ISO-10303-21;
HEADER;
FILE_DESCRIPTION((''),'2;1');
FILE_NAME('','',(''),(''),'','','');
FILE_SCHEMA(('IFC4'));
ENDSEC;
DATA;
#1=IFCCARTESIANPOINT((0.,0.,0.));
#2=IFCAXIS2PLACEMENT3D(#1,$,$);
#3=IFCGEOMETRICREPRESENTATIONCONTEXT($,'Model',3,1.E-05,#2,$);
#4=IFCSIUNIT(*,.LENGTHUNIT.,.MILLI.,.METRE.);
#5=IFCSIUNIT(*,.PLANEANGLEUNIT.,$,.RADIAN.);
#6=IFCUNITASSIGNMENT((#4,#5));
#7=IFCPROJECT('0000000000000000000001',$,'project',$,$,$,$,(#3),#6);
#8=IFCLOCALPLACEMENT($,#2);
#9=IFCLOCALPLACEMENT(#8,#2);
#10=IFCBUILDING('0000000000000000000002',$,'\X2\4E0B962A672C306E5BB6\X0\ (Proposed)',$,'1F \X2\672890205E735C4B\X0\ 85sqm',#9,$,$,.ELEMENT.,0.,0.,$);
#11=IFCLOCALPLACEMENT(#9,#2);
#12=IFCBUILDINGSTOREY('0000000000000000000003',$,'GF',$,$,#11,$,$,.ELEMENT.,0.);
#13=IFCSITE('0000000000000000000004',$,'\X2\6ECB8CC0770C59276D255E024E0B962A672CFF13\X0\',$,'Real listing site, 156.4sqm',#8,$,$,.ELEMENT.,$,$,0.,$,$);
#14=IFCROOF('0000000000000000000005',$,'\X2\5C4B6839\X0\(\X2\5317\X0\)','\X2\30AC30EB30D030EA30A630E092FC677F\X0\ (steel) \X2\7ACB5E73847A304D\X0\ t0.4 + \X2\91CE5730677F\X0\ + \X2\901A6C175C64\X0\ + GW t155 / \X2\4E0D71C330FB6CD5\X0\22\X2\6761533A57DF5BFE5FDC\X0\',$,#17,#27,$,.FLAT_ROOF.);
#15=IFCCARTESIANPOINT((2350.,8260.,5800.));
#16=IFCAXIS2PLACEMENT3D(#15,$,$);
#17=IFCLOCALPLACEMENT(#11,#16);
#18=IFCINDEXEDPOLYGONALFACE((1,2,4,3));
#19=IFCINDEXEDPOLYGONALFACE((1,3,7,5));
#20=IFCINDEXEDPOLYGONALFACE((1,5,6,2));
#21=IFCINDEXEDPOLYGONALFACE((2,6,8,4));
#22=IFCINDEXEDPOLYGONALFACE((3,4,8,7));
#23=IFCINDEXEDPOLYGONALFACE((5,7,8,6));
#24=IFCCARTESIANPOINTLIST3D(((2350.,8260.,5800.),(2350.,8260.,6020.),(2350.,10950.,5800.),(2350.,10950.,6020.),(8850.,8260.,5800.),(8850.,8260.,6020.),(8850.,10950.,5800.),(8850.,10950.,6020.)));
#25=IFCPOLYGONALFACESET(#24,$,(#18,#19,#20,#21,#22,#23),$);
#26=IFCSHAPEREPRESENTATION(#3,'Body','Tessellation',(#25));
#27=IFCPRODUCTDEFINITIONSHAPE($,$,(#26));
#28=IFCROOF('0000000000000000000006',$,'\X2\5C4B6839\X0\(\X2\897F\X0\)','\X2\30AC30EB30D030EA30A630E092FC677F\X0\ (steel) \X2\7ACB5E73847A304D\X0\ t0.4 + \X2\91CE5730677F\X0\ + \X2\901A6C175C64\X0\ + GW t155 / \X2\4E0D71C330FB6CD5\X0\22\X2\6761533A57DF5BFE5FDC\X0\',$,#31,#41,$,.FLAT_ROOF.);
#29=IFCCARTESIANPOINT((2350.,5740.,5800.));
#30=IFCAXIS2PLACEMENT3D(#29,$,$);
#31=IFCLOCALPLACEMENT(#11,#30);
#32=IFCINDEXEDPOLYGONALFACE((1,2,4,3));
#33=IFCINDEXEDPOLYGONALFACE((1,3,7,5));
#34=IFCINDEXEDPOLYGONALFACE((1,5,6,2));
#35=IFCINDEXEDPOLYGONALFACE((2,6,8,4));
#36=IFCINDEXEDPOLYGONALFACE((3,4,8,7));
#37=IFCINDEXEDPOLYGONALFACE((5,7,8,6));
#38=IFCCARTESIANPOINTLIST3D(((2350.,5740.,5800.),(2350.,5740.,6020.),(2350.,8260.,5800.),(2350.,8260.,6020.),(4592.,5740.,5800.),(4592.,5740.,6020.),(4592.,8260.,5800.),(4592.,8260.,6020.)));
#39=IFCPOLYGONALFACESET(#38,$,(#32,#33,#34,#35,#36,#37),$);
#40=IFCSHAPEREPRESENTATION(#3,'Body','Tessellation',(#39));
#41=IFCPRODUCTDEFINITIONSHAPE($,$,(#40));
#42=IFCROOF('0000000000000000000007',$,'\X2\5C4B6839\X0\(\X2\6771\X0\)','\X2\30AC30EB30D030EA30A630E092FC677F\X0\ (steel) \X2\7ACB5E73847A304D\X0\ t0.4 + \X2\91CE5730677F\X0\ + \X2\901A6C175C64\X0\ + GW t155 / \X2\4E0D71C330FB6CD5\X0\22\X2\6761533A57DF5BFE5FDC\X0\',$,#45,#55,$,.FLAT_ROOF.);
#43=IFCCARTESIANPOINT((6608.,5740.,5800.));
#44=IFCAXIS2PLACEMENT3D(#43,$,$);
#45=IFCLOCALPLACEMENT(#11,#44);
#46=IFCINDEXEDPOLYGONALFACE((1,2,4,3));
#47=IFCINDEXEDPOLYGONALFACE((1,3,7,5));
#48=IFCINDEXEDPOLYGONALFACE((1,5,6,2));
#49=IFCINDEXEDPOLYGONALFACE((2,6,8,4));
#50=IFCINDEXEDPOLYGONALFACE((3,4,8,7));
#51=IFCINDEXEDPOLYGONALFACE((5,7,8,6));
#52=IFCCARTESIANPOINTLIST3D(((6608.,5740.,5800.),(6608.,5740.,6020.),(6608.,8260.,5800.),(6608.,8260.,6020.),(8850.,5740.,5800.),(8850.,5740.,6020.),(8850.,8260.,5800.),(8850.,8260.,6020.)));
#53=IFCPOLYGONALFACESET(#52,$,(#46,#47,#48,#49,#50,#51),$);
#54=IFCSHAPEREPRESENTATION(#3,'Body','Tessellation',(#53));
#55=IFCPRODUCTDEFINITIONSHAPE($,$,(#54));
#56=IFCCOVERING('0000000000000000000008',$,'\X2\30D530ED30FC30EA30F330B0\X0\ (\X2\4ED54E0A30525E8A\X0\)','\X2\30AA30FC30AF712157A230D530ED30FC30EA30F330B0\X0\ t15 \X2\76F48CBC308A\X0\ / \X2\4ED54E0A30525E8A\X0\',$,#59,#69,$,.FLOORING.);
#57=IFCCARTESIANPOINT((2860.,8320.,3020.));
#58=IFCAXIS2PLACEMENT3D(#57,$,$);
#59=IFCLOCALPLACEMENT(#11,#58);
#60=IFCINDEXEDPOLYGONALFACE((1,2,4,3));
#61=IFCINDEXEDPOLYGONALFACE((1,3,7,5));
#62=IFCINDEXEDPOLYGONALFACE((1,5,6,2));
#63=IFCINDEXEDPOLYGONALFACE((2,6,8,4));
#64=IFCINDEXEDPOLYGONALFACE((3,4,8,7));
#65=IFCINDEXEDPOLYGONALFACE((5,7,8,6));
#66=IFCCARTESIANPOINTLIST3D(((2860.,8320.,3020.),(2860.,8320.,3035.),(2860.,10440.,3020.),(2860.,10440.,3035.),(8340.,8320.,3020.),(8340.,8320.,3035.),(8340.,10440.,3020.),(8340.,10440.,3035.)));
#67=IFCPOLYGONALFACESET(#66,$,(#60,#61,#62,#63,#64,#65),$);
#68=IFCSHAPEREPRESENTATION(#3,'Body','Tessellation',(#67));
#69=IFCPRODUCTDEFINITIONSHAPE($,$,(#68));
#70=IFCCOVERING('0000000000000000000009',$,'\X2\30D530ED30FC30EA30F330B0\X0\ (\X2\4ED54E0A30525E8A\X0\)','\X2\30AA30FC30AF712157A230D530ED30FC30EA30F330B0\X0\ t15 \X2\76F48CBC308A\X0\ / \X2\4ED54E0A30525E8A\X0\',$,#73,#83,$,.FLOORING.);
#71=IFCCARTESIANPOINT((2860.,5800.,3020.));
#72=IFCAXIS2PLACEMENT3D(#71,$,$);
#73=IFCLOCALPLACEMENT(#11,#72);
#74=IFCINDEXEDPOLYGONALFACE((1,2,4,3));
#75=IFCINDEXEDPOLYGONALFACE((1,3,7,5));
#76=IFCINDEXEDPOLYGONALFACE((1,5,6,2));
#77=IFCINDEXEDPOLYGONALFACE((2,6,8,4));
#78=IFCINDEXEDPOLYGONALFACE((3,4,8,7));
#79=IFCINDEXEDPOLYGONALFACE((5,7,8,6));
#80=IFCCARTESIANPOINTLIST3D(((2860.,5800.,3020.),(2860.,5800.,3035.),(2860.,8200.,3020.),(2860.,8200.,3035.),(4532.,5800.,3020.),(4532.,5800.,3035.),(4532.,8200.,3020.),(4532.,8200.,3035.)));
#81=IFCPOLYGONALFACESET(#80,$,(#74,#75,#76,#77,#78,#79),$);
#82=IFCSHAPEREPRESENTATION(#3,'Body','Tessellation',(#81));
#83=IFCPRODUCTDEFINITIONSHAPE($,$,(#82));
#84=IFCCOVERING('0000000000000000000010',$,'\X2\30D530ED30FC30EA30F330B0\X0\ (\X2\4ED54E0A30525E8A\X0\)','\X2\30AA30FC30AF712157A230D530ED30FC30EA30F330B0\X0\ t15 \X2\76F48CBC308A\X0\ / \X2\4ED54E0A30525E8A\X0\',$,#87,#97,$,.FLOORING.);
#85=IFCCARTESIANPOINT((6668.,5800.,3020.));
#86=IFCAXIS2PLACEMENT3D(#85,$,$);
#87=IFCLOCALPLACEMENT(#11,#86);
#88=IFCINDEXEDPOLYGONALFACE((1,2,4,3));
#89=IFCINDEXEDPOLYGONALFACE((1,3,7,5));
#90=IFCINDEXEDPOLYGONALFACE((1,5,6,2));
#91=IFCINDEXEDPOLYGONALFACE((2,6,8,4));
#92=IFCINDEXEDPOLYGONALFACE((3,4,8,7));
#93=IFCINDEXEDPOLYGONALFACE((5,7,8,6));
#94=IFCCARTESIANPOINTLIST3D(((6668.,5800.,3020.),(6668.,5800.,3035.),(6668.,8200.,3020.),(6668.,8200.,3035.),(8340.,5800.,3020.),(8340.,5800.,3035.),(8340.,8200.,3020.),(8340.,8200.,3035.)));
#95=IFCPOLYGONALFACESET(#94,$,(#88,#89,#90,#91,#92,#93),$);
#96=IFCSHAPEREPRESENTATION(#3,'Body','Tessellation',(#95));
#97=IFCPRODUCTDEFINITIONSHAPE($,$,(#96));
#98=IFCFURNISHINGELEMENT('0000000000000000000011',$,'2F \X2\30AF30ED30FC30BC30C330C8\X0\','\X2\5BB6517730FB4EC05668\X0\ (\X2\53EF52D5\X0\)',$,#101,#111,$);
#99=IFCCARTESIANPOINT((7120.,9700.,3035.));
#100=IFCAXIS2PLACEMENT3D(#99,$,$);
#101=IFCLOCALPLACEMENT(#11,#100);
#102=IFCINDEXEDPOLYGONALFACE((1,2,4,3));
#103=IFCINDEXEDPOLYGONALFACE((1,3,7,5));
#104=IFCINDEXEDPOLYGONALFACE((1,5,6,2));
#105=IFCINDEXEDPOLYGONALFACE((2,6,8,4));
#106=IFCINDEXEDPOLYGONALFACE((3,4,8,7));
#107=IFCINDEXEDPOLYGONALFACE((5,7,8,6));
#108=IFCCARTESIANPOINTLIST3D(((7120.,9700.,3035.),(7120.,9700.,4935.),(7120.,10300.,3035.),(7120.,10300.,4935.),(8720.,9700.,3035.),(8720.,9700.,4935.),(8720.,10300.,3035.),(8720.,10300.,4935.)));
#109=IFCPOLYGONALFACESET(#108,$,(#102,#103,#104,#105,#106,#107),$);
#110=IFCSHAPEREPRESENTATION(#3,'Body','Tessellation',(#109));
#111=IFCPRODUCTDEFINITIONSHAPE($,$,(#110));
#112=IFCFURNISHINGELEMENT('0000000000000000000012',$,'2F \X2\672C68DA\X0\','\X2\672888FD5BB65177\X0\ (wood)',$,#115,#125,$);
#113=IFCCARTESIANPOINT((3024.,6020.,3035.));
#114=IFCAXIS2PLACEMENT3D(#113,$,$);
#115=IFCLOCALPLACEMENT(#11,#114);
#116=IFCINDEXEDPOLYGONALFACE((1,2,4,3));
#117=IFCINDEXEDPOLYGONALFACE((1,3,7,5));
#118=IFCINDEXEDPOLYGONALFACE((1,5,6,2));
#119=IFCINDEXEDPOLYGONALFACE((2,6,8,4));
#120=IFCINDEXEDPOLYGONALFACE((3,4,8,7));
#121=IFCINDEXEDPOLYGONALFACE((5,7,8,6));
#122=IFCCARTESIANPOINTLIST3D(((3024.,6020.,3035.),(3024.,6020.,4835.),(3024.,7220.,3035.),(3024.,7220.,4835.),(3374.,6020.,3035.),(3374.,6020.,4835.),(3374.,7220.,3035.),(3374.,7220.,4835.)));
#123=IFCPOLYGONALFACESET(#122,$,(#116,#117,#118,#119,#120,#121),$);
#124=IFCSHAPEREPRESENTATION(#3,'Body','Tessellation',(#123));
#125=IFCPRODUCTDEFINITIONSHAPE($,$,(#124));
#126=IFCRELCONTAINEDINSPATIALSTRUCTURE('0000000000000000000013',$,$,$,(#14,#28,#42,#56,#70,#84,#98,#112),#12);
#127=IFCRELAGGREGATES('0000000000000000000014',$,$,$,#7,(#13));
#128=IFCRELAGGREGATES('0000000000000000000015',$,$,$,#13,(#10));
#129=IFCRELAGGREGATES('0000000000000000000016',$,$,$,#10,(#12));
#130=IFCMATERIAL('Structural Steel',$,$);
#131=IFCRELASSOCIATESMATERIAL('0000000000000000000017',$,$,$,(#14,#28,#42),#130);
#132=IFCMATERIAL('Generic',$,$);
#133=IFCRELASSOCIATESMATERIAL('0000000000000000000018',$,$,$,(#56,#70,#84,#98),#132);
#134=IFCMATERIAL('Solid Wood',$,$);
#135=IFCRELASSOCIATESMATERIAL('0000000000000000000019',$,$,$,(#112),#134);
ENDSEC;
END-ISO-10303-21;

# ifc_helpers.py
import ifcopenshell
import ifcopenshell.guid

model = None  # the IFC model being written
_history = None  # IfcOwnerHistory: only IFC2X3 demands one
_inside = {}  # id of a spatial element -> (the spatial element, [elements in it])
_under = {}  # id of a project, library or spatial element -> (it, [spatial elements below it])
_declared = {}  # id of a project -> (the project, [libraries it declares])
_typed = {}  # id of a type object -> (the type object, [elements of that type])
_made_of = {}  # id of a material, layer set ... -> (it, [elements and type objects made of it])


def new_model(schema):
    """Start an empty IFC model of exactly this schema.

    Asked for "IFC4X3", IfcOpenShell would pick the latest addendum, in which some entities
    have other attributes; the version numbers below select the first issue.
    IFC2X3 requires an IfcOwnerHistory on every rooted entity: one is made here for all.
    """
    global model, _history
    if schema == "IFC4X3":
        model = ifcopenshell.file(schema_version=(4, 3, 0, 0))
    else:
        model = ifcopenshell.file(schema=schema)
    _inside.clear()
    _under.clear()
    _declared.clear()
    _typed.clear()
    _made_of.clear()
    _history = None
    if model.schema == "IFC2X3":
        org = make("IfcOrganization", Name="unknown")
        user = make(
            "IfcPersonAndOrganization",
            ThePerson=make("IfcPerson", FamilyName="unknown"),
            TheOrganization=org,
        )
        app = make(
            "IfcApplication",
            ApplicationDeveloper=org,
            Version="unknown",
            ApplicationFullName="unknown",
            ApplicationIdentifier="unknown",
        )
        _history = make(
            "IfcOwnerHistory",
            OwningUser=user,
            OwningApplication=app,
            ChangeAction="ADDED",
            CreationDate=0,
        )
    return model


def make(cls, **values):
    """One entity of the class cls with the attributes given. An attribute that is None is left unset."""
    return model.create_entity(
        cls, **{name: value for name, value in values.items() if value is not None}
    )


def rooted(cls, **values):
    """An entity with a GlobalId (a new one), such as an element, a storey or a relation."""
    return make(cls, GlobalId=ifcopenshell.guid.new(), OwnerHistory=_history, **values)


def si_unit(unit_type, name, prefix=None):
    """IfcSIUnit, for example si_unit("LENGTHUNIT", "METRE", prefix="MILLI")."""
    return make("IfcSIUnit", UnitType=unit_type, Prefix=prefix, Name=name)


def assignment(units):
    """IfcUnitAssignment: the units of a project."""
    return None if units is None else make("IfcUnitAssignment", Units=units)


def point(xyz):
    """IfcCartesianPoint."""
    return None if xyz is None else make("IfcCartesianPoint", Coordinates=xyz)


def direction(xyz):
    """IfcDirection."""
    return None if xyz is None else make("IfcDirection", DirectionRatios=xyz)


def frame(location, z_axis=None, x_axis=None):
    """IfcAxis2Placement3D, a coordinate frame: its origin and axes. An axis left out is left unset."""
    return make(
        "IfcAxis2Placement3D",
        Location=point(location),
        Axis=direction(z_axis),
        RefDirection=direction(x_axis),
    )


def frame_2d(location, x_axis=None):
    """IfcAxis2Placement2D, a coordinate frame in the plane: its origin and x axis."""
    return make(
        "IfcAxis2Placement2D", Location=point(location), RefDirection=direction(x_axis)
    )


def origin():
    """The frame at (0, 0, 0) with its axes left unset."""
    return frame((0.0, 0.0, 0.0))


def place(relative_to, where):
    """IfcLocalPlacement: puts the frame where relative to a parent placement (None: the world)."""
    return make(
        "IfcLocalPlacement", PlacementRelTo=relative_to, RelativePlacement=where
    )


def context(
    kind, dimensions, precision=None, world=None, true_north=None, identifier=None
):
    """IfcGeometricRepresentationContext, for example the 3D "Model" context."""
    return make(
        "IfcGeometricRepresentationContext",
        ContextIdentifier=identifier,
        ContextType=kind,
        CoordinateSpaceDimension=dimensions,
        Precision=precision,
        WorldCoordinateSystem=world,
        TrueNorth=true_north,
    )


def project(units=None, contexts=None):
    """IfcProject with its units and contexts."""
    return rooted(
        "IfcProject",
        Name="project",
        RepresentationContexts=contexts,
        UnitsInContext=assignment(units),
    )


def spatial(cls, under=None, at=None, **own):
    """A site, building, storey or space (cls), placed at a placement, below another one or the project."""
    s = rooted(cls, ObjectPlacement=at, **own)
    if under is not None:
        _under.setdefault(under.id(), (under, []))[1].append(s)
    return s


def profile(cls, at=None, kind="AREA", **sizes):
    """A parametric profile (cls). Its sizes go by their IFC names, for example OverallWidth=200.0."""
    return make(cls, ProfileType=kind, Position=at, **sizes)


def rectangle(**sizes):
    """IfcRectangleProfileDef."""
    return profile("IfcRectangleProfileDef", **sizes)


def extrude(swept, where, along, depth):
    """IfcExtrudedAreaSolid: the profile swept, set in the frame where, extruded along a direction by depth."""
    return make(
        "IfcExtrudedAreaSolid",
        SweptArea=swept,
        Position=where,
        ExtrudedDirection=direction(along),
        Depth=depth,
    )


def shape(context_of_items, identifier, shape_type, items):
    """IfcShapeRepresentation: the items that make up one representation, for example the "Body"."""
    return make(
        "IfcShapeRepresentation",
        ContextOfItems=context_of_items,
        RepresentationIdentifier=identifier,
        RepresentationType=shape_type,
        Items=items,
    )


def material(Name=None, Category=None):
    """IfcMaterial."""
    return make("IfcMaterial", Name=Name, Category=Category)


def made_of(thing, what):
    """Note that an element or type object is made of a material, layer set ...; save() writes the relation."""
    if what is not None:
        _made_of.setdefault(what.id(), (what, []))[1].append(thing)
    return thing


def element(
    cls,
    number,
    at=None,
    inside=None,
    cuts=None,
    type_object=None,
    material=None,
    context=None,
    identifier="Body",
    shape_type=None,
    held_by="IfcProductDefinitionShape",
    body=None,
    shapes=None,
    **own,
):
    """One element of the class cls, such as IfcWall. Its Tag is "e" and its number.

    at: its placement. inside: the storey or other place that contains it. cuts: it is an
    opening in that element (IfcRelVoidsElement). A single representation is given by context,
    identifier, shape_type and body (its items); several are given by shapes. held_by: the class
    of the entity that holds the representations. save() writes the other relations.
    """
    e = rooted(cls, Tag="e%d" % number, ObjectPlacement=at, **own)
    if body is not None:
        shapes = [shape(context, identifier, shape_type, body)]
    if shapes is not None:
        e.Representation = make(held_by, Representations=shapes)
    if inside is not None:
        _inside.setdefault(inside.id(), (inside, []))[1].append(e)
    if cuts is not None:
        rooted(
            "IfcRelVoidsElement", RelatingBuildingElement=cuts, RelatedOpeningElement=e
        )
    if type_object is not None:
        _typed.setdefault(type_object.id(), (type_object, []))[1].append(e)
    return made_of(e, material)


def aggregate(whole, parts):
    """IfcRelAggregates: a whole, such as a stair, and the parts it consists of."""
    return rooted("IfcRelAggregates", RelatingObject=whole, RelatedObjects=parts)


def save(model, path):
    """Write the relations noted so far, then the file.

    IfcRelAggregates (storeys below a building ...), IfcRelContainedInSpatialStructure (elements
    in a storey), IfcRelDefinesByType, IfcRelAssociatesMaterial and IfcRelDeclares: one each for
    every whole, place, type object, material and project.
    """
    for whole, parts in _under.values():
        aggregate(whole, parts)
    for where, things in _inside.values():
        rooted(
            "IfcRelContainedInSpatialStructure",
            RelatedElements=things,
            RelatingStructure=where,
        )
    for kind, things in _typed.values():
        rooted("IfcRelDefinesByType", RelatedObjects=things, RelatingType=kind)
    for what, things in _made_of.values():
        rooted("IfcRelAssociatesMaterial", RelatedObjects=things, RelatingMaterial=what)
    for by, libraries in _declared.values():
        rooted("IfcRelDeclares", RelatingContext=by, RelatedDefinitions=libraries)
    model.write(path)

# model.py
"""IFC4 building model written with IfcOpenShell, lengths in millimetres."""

from ifc_helpers import new_model, si_unit, frame, frame_2d, origin, place, context, project, spatial, rectangle, extrude, material, element, save


model = new_model("IFC4")

# Units and contexts
model_context = context("Model", 3, precision=1e-05, world=origin())
ifc_project = project(units=[si_unit("LENGTHUNIT", "METRE", prefix="MILLI"), si_unit("PLANEANGLEUNIT", "RADIAN")], contexts=[model_context])

# Site, building, storey
site_placement = place(None, origin())
site = spatial("IfcSite", under=ifc_project, at=site_placement, Name="滋賀県大津市下阪本３", ObjectType="Real listing site, 156.4sqm", CompositionType="ELEMENT", RefElevation=0.0)
building_placement = place(site_placement, origin())
building = spatial("IfcBuilding", under=site, at=building_placement, Name="下阪本の家 (Proposed)", ObjectType="1F 木造平屋 85sqm", CompositionType="ELEMENT", ElevationOfRefHeight=0.0, ElevationOfTerrain=0.0)
storey_placement = place(building_placement, origin())
storey = spatial("IfcBuildingStorey", under=building, at=storey_placement, Name="GF", CompositionType="ELEMENT", Elevation=0.0)

# Shared definitions
ifc_material_1 = material(Name="Solid Wood")

# Shared definitions
ifc_material_2 = material(Name="Generic")

# Roofs
ifc_material_3 = material(Name="Structural Steel")
for number, where, name in (
    (1, (2350.0, 8260.0, 5800.0), "屋根(北)"),
):
    element("IfcRoof", number, at=place(storey_placement, frame(where)), inside=storey, material=ifc_material_3, Name=name, Description="ガルバリウム鋼板 (steel) 立平葺き t0.4 + 野地板 + 通気層 + GW t155 / 不燃・法22条区域対応", PredefinedType="FLAT_ROOF", context=model_context, shape_type="SweptSolid", body=[
        extrude(rectangle(XDim=6500.0, YDim=2690.0, at=frame_2d((3250.0, 1345.0))), frame((2350.0, 8260.0, 5800.0)), (0.0, 0.0, 1.0), 220.0),
    ])
roof_1_placement = place(storey_placement, frame((2350.0, 5740.0, 5800.0)))
element("IfcRoof", 2, at=roof_1_placement, inside=storey, material=ifc_material_3, Name="屋根(西)", Description="ガルバリウム鋼板 (steel) 立平葺き t0.4 + 野地板 + 通気層 + GW t155 / 不燃・法22条区域対応", PredefinedType="FLAT_ROOF", context=model_context, shape_type="SweptSolid", body=[
    extrude(rectangle(XDim=2242.0, YDim=2520.0, at=frame_2d((1121.0, 1260.0))), frame((2350.0, 5740.0, 5800.0)), (0.0, 0.0, 1.0), 220.0),
])
roof_2_placement = place(storey_placement, frame((6608.0, 5740.0, 5800.0)))
element("IfcRoof", 3, at=roof_2_placement, inside=storey, material=ifc_material_3, Name="屋根(東)", Description="ガルバリウム鋼板 (steel) 立平葺き t0.4 + 野地板 + 通気層 + GW t155 / 不燃・法22条区域対応", PredefinedType="FLAT_ROOF", context=model_context, shape_type="SweptSolid", body=[
    extrude(rectangle(XDim=2242.0, YDim=2520.0, at=frame_2d((1121.0, 1260.0))), frame((6608.0, 5740.0, 5800.0)), (0.0, 0.0, 1.0), 220.0),
])

# Coverings
covering_1_placement = place(storey_placement, frame((2860.0, 8320.0, 3020.0)))
element("IfcCovering", 4, at=covering_1_placement, inside=storey, material=ifc_material_2, Name="フローリング (仕上げ床)", Description="オーク無垢フローリング t15 直貼り / 仕上げ床", PredefinedType="FLOORING", context=model_context, shape_type="SweptSolid", body=[
    extrude(rectangle(XDim=5480.0, YDim=2120.0, at=frame_2d((2740.0, 1060.0))), frame((2860.0, 8320.0, 3020.0)), (0.0, 0.0, 1.0), 15.0),
])
covering_2_placement = place(storey_placement, frame((2860.0, 5800.0, 3020.0)))
element("IfcCovering", 5, at=covering_2_placement, inside=storey, material=ifc_material_2, Name="フローリング (仕上げ床)", Description="オーク無垢フローリング t15 直貼り / 仕上げ床", PredefinedType="FLOORING", context=model_context, shape_type="SweptSolid", body=[
    extrude(rectangle(XDim=1672.0, YDim=2400.0, at=frame_2d((836.0, 1200.0))), frame((2860.0, 5800.0, 3020.0)), (0.0, 0.0, 1.0), 15.0),
])
covering_3_placement = place(storey_placement, frame((6668.0, 5800.0, 3020.0)))
element("IfcCovering", 6, at=covering_3_placement, inside=storey, material=ifc_material_2, Name="フローリング (仕上げ床)", Description="オーク無垢フローリング t15 直貼り / 仕上げ床", PredefinedType="FLOORING", context=model_context, shape_type="SweptSolid", body=[
    extrude(rectangle(XDim=1672.0, YDim=2400.0, at=frame_2d((836.0, 1200.0))), frame((6668.0, 5800.0, 3020.0)), (0.0, 0.0, 1.0), 15.0),
])

# Furnishing elements
furnishing_1_placement = place(storey_placement, frame((7120.0, 9700.0, 3035.0)))
element("IfcFurnishingElement", 7, at=furnishing_1_placement, inside=storey, material=ifc_material_2, Name="2F クローゼット", Description="家具・什器 (可動)", context=model_context, shape_type="SweptSolid", body=[
    extrude(rectangle(XDim=1600.0, YDim=600.0, at=frame_2d((800.0, 300.0))), frame((7120.0, 9700.0, 3035.0)), (0.0, 0.0, 1.0), 1900.0),
])
furnishing_2_placement = place(storey_placement, frame((3024.0, 6020.0, 3035.0)))
element("IfcFurnishingElement", 8, at=furnishing_2_placement, inside=storey, material=ifc_material_1, Name="2F 本棚", Description="木製家具 (wood)", context=model_context, shape_type="SweptSolid", body=[
    extrude(rectangle(XDim=350.0, YDim=1200.0, at=frame_2d((175.0, 600.0))), frame((3024.0, 6020.0, 3035.0)), (0.0, 0.0, 1.0), 1800.0),
])

save(model, "model.ifc")
